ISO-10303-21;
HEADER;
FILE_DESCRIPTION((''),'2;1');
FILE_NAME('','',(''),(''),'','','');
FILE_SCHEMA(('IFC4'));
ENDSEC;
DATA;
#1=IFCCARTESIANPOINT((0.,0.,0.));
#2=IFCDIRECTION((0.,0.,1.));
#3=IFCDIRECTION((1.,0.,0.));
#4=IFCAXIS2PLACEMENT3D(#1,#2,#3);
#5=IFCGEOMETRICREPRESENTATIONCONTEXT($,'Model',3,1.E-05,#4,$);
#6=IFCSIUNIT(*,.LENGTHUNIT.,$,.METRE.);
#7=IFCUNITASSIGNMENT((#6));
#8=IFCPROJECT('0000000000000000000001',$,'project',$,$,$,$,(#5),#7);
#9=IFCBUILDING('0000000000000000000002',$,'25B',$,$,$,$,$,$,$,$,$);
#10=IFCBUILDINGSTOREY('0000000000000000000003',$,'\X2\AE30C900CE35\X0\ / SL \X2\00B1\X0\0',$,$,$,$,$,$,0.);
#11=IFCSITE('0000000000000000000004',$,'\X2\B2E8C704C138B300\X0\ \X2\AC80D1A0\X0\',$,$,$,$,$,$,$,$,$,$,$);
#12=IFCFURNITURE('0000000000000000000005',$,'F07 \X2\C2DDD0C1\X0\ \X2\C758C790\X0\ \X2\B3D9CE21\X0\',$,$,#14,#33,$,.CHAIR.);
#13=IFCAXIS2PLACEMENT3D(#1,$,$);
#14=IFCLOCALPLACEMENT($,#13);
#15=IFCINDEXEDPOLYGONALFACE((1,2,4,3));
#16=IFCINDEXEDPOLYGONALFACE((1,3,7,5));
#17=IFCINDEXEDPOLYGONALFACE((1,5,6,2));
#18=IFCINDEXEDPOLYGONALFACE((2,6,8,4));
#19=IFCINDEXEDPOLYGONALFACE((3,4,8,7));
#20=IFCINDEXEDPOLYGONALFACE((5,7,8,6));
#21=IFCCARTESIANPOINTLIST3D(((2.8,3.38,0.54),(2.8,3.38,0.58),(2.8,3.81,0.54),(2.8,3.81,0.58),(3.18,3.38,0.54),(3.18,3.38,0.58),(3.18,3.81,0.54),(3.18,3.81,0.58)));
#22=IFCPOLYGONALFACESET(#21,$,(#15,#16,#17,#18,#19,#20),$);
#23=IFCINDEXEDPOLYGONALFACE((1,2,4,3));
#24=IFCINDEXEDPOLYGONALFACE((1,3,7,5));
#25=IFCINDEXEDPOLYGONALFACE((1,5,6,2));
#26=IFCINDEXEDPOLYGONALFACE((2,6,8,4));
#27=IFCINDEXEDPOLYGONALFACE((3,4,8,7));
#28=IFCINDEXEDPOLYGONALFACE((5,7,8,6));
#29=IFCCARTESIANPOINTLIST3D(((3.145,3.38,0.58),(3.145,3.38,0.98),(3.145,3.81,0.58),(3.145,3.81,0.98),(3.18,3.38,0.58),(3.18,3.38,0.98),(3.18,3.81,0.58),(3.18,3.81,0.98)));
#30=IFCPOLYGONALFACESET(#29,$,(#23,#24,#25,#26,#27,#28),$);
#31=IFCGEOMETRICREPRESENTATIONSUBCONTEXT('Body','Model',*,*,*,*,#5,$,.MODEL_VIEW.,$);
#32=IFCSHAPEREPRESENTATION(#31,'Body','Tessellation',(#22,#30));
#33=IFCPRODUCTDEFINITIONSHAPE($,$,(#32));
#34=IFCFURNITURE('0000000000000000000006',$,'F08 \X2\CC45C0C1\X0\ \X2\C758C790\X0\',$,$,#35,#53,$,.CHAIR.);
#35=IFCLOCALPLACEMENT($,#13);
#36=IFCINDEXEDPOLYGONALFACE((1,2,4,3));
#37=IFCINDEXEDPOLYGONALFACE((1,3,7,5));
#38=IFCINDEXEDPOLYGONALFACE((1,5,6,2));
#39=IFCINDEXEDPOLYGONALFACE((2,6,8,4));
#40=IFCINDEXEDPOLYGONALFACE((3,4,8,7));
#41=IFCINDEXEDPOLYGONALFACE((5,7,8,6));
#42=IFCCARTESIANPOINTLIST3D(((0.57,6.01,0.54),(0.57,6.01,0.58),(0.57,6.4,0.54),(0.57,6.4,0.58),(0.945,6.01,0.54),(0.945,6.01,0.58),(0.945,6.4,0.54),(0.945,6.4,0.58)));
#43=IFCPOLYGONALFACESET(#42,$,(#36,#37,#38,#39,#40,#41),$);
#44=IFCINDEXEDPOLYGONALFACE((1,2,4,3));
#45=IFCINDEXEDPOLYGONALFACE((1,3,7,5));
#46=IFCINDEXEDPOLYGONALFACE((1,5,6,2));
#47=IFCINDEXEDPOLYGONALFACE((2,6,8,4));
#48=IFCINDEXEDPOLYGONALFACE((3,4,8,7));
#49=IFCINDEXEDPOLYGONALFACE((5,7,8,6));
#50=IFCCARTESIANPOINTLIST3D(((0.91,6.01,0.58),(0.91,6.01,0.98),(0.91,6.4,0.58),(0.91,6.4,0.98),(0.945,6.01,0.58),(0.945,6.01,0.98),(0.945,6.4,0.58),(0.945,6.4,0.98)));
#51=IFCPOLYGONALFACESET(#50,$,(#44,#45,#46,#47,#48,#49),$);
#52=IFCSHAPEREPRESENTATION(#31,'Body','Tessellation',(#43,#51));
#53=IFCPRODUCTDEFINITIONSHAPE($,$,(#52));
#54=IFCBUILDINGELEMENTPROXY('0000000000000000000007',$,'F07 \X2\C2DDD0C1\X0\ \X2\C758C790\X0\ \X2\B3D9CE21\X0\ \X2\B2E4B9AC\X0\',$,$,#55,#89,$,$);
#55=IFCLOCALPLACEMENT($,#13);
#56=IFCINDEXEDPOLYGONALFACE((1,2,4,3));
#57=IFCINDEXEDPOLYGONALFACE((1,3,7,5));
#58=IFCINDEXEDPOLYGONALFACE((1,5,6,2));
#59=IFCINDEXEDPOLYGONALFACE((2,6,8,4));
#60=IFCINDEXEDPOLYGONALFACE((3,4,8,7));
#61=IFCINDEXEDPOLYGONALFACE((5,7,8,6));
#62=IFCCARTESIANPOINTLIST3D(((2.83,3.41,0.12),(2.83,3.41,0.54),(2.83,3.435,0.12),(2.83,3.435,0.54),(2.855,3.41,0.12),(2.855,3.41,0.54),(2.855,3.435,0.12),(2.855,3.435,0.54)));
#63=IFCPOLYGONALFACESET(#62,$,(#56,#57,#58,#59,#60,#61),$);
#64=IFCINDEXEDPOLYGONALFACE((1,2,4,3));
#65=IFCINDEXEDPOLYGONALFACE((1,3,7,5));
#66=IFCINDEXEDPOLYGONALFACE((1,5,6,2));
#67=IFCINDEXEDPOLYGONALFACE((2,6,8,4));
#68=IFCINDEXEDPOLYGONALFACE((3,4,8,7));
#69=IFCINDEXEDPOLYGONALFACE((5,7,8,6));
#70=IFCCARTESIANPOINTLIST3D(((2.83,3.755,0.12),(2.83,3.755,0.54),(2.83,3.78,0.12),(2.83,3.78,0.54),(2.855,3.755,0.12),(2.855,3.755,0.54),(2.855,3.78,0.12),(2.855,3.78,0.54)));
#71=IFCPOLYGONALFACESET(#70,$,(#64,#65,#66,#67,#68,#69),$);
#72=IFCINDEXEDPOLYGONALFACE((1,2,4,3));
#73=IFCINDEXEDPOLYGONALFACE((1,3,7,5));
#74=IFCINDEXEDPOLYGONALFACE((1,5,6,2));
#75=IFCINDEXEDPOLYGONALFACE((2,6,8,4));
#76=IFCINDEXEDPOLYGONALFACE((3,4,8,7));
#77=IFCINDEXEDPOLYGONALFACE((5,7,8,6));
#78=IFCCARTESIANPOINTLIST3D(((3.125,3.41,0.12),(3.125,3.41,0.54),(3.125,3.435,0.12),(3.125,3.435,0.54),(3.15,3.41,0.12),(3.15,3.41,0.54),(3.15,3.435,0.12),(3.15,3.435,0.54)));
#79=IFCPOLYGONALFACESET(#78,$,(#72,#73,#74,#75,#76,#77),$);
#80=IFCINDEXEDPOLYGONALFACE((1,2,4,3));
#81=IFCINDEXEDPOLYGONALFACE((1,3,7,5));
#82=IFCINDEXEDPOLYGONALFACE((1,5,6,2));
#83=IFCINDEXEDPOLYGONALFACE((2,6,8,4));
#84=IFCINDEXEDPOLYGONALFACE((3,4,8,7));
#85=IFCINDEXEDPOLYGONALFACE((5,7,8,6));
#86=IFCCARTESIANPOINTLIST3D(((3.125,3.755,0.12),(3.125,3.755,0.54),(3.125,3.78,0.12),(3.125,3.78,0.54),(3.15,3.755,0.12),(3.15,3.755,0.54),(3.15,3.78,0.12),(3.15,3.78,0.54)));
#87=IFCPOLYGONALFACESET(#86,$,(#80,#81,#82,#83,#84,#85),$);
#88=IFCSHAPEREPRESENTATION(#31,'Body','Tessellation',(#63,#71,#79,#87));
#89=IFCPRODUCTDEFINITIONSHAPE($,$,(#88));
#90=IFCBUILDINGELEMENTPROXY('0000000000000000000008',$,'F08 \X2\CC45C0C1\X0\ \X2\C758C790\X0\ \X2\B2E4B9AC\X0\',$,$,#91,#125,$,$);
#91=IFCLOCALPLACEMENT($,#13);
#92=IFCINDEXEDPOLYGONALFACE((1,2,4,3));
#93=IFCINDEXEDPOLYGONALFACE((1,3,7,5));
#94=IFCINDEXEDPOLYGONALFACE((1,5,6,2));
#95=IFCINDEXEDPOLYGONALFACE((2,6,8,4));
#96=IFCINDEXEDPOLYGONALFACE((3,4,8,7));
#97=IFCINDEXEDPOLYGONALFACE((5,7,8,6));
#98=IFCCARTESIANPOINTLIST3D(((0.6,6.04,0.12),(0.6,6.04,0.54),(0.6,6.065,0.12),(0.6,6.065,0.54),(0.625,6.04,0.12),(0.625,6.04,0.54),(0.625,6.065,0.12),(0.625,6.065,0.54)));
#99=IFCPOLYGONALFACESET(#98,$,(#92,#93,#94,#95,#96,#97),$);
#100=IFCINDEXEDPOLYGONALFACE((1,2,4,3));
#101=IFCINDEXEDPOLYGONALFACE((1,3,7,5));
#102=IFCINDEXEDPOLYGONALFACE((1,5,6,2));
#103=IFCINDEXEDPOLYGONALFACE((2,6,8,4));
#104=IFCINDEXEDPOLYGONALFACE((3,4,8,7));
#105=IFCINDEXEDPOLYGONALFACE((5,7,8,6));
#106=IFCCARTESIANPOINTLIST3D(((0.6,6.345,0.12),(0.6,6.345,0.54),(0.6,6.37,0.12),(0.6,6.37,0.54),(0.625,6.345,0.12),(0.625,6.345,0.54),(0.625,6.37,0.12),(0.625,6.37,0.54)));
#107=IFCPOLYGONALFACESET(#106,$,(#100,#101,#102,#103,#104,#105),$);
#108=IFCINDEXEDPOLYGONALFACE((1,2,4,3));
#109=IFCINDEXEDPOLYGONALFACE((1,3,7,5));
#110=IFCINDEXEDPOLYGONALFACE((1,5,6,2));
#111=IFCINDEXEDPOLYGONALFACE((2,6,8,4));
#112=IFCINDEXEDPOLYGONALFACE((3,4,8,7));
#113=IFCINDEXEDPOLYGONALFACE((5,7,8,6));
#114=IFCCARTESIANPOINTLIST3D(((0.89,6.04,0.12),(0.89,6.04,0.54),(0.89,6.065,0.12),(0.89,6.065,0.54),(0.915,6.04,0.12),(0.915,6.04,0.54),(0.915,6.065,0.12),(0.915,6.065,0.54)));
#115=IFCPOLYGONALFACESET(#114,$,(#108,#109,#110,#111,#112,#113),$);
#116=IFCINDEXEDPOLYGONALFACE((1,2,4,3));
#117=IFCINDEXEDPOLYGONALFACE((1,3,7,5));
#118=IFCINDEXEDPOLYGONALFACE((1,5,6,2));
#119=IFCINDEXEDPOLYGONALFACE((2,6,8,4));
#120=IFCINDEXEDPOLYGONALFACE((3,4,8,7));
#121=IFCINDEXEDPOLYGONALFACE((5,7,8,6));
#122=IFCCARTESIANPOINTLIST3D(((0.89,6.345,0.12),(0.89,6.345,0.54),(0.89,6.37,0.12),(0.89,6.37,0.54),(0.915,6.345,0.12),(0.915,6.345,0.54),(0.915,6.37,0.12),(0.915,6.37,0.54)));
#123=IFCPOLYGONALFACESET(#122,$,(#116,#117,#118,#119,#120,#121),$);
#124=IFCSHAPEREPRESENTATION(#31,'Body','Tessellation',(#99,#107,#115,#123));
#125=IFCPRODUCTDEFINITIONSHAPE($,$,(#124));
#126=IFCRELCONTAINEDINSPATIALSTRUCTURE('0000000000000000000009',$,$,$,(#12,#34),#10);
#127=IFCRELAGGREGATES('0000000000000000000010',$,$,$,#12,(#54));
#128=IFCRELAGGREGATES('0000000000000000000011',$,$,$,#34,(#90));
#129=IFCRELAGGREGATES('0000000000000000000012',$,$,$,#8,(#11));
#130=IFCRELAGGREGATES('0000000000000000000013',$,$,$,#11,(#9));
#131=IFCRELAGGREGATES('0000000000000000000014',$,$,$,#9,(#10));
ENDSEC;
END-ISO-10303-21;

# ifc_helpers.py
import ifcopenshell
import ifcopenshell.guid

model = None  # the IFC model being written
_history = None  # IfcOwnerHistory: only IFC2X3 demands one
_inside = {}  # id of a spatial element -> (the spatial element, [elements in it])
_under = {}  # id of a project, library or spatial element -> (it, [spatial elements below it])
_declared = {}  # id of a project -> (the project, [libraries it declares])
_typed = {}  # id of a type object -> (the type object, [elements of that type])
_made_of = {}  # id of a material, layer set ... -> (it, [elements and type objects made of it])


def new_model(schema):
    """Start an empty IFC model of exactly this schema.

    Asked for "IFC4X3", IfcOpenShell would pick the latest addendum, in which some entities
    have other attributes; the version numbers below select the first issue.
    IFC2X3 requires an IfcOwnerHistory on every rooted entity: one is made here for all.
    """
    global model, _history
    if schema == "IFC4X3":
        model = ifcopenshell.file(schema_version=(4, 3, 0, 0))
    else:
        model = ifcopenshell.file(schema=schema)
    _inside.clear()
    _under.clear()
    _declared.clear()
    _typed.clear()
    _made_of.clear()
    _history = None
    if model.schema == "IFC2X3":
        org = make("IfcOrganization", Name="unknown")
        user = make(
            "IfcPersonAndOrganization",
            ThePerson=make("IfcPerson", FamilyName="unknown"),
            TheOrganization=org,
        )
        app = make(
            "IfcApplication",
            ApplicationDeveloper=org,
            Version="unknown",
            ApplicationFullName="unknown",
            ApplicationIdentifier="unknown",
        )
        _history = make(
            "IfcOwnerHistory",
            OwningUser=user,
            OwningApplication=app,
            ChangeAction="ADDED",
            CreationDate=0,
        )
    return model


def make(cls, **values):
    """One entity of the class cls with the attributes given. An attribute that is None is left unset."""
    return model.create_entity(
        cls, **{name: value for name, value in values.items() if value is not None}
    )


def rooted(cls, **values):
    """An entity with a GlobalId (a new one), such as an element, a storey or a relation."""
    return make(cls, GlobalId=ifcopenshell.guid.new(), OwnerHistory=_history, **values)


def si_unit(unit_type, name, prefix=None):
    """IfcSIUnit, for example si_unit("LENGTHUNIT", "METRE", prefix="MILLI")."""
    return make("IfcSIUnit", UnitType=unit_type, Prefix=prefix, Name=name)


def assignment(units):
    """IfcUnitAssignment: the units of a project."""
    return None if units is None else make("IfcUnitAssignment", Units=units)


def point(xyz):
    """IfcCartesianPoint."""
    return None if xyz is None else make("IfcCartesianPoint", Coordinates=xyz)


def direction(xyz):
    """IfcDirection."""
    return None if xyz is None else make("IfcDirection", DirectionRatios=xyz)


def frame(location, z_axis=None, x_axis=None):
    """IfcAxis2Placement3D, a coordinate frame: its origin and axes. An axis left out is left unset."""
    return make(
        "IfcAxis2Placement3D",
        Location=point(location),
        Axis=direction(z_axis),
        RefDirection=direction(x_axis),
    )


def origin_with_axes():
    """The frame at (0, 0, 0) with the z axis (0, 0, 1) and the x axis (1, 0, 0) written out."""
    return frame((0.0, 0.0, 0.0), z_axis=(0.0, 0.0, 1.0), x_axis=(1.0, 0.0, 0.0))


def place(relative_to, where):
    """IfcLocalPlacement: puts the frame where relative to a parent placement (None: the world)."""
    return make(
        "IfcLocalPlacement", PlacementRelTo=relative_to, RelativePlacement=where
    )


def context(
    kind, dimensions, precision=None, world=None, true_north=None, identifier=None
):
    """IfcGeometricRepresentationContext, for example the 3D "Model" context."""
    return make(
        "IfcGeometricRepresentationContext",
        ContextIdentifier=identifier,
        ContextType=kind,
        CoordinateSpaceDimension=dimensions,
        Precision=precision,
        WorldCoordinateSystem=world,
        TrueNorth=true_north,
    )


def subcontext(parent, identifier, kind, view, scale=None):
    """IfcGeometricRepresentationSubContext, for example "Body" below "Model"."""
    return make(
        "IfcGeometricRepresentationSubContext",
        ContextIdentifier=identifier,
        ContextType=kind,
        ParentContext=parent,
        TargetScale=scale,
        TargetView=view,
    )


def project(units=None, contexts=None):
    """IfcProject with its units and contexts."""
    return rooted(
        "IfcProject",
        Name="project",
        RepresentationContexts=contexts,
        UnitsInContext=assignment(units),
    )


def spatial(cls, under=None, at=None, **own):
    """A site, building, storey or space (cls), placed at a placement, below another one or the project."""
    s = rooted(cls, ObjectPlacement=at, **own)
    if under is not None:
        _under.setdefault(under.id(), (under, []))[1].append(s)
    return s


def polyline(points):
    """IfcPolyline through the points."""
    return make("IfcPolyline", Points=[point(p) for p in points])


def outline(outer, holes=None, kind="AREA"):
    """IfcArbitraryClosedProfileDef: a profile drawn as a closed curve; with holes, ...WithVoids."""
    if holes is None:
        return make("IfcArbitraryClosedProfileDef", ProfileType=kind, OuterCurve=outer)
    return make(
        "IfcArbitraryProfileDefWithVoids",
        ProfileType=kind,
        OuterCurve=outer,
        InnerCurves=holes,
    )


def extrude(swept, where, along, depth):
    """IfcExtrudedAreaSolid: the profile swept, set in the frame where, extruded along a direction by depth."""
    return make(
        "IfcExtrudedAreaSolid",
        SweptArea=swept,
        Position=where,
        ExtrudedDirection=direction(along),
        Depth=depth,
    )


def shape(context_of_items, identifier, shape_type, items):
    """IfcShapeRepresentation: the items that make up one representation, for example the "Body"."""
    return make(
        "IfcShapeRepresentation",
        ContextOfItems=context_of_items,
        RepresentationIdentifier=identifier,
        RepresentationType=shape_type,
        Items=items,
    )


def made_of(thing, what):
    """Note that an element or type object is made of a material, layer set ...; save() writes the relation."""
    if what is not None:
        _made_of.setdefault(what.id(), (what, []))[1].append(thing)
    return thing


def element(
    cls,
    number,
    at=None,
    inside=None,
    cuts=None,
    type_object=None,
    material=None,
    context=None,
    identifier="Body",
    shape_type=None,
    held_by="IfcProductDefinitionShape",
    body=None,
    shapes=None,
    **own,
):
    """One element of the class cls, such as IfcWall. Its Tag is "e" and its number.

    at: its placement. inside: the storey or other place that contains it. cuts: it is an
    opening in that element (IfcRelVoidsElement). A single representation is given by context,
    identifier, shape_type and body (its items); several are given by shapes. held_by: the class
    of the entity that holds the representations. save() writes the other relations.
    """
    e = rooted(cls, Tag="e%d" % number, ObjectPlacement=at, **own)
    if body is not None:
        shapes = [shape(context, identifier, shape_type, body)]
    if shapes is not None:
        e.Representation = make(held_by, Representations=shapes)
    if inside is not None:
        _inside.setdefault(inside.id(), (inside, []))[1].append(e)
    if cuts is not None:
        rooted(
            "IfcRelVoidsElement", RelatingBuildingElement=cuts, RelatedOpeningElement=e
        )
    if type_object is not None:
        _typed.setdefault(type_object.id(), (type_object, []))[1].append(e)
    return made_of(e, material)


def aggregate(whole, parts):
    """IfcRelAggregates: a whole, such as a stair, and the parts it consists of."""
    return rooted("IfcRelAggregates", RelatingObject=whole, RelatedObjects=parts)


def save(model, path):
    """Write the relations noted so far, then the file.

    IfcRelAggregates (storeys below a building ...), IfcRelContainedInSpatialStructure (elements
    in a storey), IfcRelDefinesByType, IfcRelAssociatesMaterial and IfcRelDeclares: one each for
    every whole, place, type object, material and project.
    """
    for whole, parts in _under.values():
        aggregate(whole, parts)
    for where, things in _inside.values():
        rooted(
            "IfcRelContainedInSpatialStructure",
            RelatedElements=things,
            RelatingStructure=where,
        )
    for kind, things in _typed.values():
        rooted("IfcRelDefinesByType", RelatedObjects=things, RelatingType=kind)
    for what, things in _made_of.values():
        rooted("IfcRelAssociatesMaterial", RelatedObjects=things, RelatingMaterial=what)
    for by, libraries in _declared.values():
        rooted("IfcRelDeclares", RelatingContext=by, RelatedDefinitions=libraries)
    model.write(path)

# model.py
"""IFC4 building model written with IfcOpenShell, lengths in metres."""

from ifc_helpers import new_model, si_unit, frame, origin_with_axes, place, context, subcontext, project, spatial, polyline, outline, extrude, element, aggregate, save


model = new_model("IFC4")

# Units and contexts
model_context = context("Model", 3, precision=1e-05, world=origin_with_axes())
body_context = subcontext(model_context, "Body", "Model", "MODEL_VIEW")
ifc_project = project(units=[si_unit("LENGTHUNIT", "METRE")], contexts=[model_context])

# Site, building, storey
site = spatial("IfcSite", under=ifc_project, Name="단위세대 검토")
building = spatial("IfcBuilding", under=site, Name="25B")
storey = spatial("IfcBuildingStorey", under=building, Name="기준층 / SL ±0", Elevation=0.0)

# Furniture
furniture_1_placement = place(None, origin_with_axes())
furniture_1 = element("IfcFurniture", 1, at=furniture_1_placement, inside=storey, Name="F07 식탁 의자 동측", PredefinedType="CHAIR", context=body_context, shape_type="SweptSolid", body=[
    extrude(outline(polyline([(3.18, 3.38), (3.18, 3.81), (2.8, 3.81), (2.8, 3.38), (3.18, 3.38)])), frame((0.0, 0.0, 0.54)), (0.0, 0.0, 1.0), 0.04),
    extrude(outline(polyline([(3.18, 3.38), (3.18, 3.81), (3.145, 3.81), (3.145, 3.38), (3.18, 3.38)])), frame((0.0, 0.0, 0.58)), (0.0, 0.0, 1.0), 0.4),
])
furniture_2_placement = place(None, origin_with_axes())
furniture_2 = element("IfcFurniture", 2, at=furniture_2_placement, inside=storey, Name="F08 책상 의자", PredefinedType="CHAIR", context=body_context, shape_type="SweptSolid", body=[
    extrude(outline(polyline([(0.945, 6.01), (0.945, 6.4), (0.57, 6.4), (0.57, 6.01), (0.945, 6.01)])), frame((0.0, 0.0, 0.54)), (0.0, 0.0, 1.0), 0.04),
    extrude(outline(polyline([(0.945, 6.01), (0.945, 6.4), (0.91, 6.4), (0.91, 6.01), (0.945, 6.01)])), frame((0.0, 0.0, 0.58)), (0.0, 0.0, 1.0), 0.4),
])

# Building element proxies
proxy_1_placement = place(furniture_1_placement, origin_with_axes())
proxy_1 = element("IfcBuildingElementProxy", 3, at=proxy_1_placement, Name="F07 식탁 의자 동측 다리", context=body_context, shape_type="SweptSolid", body=[
    extrude(outline(polyline([(2.855, 3.41), (2.855, 3.435), (2.83, 3.435), (2.83, 3.41), (2.855, 3.41)])), frame((0.0, 0.0, 0.12)), (0.0, 0.0, 1.0), 0.42),
    extrude(outline(polyline([(2.855, 3.755), (2.855, 3.78), (2.83, 3.78), (2.83, 3.755), (2.855, 3.755)])), frame((0.0, 0.0, 0.12)), (0.0, 0.0, 1.0), 0.42),
    extrude(outline(polyline([(3.15, 3.41), (3.15, 3.435), (3.125, 3.435), (3.125, 3.41), (3.15, 3.41)])), frame((0.0, 0.0, 0.12)), (0.0, 0.0, 1.0), 0.42),
    extrude(outline(polyline([(3.15, 3.755), (3.15, 3.78), (3.125, 3.78), (3.125, 3.755), (3.15, 3.755)])), frame((0.0, 0.0, 0.12)), (0.0, 0.0, 1.0), 0.42),
])
aggregate(furniture_1, [proxy_1])
proxy_2_placement = place(furniture_2_placement, origin_with_axes())
proxy_2 = element("IfcBuildingElementProxy", 4, at=proxy_2_placement, Name="F08 책상 의자 다리", context=body_context, shape_type="SweptSolid", body=[
    extrude(outline(polyline([(0.625, 6.04), (0.625, 6.065), (0.6, 6.065), (0.6, 6.04), (0.625, 6.04)])), frame((0.0, 0.0, 0.12)), (0.0, 0.0, 1.0), 0.42),
    extrude(outline(polyline([(0.625, 6.345), (0.625, 6.37), (0.6, 6.37), (0.6, 6.345), (0.625, 6.345)])), frame((0.0, 0.0, 0.12)), (0.0, 0.0, 1.0), 0.42),
    extrude(outline(polyline([(0.915, 6.04), (0.915, 6.065), (0.89, 6.065), (0.89, 6.04), (0.915, 6.04)])), frame((0.0, 0.0, 0.12)), (0.0, 0.0, 1.0), 0.42),
    extrude(outline(polyline([(0.915, 6.345), (0.915, 6.37), (0.89, 6.37), (0.89, 6.345), (0.915, 6.345)])), frame((0.0, 0.0, 0.12)), (0.0, 0.0, 1.0), 0.42),
])
aggregate(furniture_2, [proxy_2])

save(model, "model.ifc")
